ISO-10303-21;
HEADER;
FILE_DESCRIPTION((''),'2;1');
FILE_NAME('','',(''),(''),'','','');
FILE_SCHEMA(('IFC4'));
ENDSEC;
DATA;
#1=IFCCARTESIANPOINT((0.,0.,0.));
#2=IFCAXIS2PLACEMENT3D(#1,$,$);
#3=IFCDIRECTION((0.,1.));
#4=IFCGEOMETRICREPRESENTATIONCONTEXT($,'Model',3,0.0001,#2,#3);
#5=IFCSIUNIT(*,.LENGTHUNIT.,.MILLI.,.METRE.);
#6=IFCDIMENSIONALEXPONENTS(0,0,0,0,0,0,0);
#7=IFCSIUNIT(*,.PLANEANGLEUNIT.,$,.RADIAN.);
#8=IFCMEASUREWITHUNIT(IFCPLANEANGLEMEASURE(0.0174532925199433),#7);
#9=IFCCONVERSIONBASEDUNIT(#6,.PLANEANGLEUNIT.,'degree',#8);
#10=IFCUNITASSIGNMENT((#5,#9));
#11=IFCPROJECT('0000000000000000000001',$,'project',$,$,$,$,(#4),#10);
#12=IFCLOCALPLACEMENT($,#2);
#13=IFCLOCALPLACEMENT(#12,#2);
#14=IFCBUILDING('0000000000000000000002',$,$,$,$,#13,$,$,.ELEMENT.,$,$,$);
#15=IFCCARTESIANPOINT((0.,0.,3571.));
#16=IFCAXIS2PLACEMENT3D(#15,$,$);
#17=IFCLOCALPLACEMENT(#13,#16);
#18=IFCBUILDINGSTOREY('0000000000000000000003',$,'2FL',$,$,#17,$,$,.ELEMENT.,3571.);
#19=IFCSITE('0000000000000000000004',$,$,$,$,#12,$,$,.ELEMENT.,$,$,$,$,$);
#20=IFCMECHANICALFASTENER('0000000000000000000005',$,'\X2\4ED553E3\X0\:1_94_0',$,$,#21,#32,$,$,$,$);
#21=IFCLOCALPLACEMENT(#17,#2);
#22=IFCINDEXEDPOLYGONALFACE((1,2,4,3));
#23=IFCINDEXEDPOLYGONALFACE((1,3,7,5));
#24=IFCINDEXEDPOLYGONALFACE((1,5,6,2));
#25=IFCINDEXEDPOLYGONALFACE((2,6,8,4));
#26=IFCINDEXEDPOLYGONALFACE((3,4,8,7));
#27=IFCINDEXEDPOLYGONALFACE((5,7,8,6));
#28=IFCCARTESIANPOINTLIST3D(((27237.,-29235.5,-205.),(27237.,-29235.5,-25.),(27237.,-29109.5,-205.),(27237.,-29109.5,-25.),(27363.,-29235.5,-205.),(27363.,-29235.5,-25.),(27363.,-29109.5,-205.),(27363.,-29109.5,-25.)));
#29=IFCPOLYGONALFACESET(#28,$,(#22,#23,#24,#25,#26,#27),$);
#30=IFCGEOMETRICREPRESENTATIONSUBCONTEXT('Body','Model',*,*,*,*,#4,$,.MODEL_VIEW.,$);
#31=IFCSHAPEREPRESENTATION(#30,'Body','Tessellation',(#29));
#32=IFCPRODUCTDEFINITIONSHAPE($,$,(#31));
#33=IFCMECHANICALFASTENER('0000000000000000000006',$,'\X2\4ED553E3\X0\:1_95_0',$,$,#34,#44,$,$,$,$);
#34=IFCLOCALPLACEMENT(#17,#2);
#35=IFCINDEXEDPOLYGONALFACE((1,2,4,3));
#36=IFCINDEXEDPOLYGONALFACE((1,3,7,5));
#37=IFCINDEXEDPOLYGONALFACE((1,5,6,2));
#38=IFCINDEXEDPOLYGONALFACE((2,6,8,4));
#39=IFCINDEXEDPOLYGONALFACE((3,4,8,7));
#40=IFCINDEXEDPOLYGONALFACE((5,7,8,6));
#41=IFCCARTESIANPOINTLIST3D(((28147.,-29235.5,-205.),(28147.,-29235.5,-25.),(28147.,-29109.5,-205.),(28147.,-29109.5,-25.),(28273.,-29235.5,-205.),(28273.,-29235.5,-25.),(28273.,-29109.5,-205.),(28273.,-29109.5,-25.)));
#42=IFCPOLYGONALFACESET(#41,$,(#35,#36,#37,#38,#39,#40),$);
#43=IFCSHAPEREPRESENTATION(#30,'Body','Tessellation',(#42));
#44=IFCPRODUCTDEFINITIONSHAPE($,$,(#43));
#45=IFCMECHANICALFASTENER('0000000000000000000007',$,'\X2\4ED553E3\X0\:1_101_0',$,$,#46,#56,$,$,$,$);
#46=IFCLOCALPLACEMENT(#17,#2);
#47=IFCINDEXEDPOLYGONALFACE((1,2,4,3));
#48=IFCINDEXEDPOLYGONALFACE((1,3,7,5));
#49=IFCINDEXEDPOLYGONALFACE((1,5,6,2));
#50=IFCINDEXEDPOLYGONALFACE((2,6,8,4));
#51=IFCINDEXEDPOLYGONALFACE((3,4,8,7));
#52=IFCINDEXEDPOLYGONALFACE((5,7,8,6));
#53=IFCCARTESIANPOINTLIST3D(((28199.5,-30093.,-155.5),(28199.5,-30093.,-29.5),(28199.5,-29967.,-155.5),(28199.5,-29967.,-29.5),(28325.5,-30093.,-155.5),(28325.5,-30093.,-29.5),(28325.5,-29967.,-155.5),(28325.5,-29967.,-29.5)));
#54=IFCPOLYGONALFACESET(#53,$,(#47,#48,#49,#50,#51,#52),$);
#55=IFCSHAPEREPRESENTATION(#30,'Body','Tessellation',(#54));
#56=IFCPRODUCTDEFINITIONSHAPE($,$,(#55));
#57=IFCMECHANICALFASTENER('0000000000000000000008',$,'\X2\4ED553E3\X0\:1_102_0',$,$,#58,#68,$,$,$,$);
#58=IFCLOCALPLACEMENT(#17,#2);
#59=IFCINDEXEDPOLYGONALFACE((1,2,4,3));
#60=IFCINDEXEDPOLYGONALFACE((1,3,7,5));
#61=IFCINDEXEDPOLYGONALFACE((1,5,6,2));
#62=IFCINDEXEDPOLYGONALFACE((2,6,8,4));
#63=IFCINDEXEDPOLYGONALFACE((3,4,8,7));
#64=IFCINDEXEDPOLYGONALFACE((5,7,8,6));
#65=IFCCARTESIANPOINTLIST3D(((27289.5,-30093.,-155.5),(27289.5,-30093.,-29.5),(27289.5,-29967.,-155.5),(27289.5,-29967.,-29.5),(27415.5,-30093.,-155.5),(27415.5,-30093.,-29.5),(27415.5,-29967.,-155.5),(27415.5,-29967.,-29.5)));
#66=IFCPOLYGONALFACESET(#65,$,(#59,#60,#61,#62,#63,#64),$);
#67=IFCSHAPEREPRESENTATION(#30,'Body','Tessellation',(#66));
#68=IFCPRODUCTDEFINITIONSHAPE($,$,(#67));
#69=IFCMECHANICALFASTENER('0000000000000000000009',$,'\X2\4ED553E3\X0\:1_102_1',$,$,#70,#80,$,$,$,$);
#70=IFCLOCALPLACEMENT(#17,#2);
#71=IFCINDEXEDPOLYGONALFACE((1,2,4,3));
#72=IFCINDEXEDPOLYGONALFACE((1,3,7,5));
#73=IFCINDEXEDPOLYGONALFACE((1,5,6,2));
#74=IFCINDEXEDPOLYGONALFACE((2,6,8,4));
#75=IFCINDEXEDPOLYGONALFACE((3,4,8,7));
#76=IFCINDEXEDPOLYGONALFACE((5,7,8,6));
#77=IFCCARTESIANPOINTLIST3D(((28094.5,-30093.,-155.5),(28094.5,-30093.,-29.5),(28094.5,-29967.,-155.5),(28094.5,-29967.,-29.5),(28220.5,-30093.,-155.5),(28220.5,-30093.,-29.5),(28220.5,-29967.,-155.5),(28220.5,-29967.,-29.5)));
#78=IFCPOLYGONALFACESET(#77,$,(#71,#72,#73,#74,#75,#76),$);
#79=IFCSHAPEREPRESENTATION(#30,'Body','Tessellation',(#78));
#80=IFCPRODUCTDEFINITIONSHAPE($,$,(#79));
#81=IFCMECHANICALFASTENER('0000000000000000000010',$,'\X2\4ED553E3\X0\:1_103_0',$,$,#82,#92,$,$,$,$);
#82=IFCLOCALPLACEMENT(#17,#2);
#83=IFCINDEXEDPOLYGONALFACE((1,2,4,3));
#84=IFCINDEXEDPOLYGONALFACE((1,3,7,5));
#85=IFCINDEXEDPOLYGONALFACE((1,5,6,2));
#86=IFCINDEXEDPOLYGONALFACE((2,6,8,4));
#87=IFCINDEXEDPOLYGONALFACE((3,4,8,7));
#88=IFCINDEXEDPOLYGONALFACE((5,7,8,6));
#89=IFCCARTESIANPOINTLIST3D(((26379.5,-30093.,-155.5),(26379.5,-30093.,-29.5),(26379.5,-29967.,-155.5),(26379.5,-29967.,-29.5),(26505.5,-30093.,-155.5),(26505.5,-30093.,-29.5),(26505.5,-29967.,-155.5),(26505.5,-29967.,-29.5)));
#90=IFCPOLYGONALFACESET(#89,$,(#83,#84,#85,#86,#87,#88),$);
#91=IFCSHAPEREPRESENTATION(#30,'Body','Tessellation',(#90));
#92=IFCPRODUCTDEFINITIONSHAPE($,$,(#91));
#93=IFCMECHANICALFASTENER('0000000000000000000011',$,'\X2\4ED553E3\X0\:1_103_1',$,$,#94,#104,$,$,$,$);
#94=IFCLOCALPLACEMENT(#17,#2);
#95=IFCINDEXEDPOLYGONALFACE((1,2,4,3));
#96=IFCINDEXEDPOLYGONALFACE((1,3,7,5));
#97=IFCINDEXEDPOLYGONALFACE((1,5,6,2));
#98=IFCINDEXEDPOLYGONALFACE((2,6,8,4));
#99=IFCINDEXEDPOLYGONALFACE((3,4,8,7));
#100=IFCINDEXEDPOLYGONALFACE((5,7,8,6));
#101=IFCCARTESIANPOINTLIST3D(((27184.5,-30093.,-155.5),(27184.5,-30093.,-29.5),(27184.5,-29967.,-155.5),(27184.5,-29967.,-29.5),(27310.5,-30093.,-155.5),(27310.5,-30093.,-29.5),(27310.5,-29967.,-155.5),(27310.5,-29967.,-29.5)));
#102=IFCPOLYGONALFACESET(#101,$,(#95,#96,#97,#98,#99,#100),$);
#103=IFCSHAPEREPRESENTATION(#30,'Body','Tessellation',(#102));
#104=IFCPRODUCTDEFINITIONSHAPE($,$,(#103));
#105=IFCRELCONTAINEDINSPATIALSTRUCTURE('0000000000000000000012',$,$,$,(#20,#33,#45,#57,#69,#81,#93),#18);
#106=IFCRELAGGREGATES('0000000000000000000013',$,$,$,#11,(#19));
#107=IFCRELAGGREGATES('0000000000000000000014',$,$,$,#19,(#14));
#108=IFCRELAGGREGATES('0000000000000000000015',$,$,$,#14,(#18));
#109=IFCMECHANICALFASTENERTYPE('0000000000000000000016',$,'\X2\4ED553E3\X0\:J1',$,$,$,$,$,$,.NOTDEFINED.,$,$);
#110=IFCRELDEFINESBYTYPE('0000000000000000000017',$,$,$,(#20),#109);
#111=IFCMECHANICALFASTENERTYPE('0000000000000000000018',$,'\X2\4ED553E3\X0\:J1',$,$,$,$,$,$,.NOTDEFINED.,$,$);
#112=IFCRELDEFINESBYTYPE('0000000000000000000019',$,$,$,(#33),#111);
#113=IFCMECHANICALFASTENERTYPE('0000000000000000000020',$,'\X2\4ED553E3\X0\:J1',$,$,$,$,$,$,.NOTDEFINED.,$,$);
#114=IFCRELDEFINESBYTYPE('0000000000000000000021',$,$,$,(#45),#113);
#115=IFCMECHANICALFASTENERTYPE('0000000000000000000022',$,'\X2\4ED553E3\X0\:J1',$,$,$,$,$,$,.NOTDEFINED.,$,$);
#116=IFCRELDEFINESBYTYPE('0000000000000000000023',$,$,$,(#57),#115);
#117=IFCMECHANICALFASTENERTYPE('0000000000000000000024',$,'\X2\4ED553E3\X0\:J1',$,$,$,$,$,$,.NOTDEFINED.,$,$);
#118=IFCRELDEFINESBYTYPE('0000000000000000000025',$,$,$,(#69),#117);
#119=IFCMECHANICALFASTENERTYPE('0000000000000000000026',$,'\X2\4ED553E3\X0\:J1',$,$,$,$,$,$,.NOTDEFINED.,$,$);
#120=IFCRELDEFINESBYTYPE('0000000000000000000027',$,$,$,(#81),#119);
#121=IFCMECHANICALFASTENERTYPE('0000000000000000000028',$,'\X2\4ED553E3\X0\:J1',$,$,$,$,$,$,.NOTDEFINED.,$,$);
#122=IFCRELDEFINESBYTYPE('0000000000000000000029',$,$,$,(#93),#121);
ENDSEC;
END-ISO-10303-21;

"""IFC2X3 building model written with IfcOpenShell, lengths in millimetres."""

from ifc_helpers import new_model, entity, si_unit, converted_unit, direction, frame, origin, origin_with_axes, origin_2d, place, context, subcontext, project, spatial, rectangle, extrude, type_object, element, save


model = new_model("IFC2X3")

# Units and contexts
model_context = context("Model", 3, precision=0.0001, world=origin(), true_north=direction((0.0, 1.0)))
body_context = subcontext(model_context, "Body", "Model", "MODEL_VIEW")
ifc_project = project(units=[si_unit("LENGTHUNIT", "METRE", prefix="MILLI"), converted_unit("PLANEANGLEUNIT", "degree", entity("IfcPlaneAngleMeasure", 0.0174532925199433), si_unit("PLANEANGLEUNIT", "RADIAN"), dimensions=[0, 0, 0, 0, 0, 0, 0])], contexts=[model_context])

# Site, building, storey
site_placement = place(None, origin())
site = spatial("IfcSite", under=ifc_project, at=site_placement, CompositionType="ELEMENT")
building_placement = place(site_placement, origin())
building = spatial("IfcBuilding", under=site, at=building_placement, CompositionType="ELEMENT")
storey_placement = place(building_placement, frame((0.0, 0.0, 3571.0)))
storey = spatial("IfcBuildingStorey", under=building, at=storey_placement, Name="2FL", CompositionType="ELEMENT", Elevation=3571.0)

# Mechanical fasteners
mechanical_fastener_type_1 = type_object("IfcMechanicalFastenerType", Name="仕口:J1")
mechanical_fastener_1_placement = place(storey_placement, frame((27300.0, -29172.5, -205.0)))
element("IfcMechanicalFastener", 1, at=mechanical_fastener_1_placement, inside=storey, type_object=mechanical_fastener_type_1, Name="仕口:1_94_0", context=body_context, shape_type="SweptSolid", body=[
    extrude(rectangle(XDim=126.0, YDim=126.0, at=origin_2d()), origin_with_axes(), (0.0, 0.0, 1.0), 180.0),
])
mechanical_fastener_type_2 = type_object("IfcMechanicalFastenerType", Name="仕口:J1")
mechanical_fastener_2_placement = place(storey_placement, frame((28210.0, -29172.5, -205.0)))
element("IfcMechanicalFastener", 2, at=mechanical_fastener_2_placement, inside=storey, type_object=mechanical_fastener_type_2, Name="仕口:1_95_0", context=body_context, shape_type="SweptSolid", body=[
    extrude(rectangle(XDim=126.0, YDim=126.0, at=origin_2d()), origin_with_axes(), (0.0, 0.0, 1.0), 180.0),
])
mechanical_fastener_type_3 = type_object("IfcMechanicalFastenerType", Name="仕口:J1")
mechanical_fastener_3_placement = place(storey_placement, frame((28262.5, -30030.0, -155.5)))
element("IfcMechanicalFastener", 3, at=mechanical_fastener_3_placement, inside=storey, type_object=mechanical_fastener_type_3, Name="仕口:1_101_0", context=body_context, shape_type="SweptSolid", body=[
    extrude(rectangle(XDim=126.0, YDim=126.0, at=origin_2d()), origin_with_axes(), (0.0, 0.0, 1.0), 126.0),
])
mechanical_fastener_type_4 = type_object("IfcMechanicalFastenerType", Name="仕口:J1")
mechanical_fastener_4_placement = place(storey_placement, frame((27352.5, -30030.0, -155.5)))
element("IfcMechanicalFastener", 4, at=mechanical_fastener_4_placement, inside=storey, type_object=mechanical_fastener_type_4, Name="仕口:1_102_0", context=body_context, shape_type="SweptSolid", body=[
    extrude(rectangle(XDim=126.0, YDim=126.0, at=origin_2d()), origin_with_axes(), (0.0, 0.0, 1.0), 126.0),
])
mechanical_fastener_type_5 = type_object("IfcMechanicalFastenerType", Name="仕口:J1")
mechanical_fastener_5_placement = place(storey_placement, frame((28157.5, -30030.0, -155.5)))
element("IfcMechanicalFastener", 5, at=mechanical_fastener_5_placement, inside=storey, type_object=mechanical_fastener_type_5, Name="仕口:1_102_1", context=body_context, shape_type="SweptSolid", body=[
    extrude(rectangle(XDim=126.0, YDim=126.0, at=origin_2d()), origin_with_axes(), (0.0, 0.0, 1.0), 126.0),
])
mechanical_fastener_type_6 = type_object("IfcMechanicalFastenerType", Name="仕口:J1")
mechanical_fastener_6_placement = place(storey_placement, frame((26442.5, -30030.0, -155.5)))
element("IfcMechanicalFastener", 6, at=mechanical_fastener_6_placement, inside=storey, type_object=mechanical_fastener_type_6, Name="仕口:1_103_0", context=body_context, shape_type="SweptSolid", body=[
    extrude(rectangle(XDim=126.0, YDim=126.0, at=origin_2d()), origin_with_axes(), (0.0, 0.0, 1.0), 126.0),
])
mechanical_fastener_type_7 = type_object("IfcMechanicalFastenerType", Name="仕口:J1")
mechanical_fastener_7_placement = place(storey_placement, frame((27247.5, -30030.0, -155.5)))
element("IfcMechanicalFastener", 7, at=mechanical_fastener_7_placement, inside=storey, type_object=mechanical_fastener_type_7, Name="仕口:1_103_1", context=body_context, shape_type="SweptSolid", body=[
    extrude(rectangle(XDim=126.0, YDim=126.0, at=origin_2d()), origin_with_axes(), (0.0, 0.0, 1.0), 126.0),
])

save(model, "model.ifc")
